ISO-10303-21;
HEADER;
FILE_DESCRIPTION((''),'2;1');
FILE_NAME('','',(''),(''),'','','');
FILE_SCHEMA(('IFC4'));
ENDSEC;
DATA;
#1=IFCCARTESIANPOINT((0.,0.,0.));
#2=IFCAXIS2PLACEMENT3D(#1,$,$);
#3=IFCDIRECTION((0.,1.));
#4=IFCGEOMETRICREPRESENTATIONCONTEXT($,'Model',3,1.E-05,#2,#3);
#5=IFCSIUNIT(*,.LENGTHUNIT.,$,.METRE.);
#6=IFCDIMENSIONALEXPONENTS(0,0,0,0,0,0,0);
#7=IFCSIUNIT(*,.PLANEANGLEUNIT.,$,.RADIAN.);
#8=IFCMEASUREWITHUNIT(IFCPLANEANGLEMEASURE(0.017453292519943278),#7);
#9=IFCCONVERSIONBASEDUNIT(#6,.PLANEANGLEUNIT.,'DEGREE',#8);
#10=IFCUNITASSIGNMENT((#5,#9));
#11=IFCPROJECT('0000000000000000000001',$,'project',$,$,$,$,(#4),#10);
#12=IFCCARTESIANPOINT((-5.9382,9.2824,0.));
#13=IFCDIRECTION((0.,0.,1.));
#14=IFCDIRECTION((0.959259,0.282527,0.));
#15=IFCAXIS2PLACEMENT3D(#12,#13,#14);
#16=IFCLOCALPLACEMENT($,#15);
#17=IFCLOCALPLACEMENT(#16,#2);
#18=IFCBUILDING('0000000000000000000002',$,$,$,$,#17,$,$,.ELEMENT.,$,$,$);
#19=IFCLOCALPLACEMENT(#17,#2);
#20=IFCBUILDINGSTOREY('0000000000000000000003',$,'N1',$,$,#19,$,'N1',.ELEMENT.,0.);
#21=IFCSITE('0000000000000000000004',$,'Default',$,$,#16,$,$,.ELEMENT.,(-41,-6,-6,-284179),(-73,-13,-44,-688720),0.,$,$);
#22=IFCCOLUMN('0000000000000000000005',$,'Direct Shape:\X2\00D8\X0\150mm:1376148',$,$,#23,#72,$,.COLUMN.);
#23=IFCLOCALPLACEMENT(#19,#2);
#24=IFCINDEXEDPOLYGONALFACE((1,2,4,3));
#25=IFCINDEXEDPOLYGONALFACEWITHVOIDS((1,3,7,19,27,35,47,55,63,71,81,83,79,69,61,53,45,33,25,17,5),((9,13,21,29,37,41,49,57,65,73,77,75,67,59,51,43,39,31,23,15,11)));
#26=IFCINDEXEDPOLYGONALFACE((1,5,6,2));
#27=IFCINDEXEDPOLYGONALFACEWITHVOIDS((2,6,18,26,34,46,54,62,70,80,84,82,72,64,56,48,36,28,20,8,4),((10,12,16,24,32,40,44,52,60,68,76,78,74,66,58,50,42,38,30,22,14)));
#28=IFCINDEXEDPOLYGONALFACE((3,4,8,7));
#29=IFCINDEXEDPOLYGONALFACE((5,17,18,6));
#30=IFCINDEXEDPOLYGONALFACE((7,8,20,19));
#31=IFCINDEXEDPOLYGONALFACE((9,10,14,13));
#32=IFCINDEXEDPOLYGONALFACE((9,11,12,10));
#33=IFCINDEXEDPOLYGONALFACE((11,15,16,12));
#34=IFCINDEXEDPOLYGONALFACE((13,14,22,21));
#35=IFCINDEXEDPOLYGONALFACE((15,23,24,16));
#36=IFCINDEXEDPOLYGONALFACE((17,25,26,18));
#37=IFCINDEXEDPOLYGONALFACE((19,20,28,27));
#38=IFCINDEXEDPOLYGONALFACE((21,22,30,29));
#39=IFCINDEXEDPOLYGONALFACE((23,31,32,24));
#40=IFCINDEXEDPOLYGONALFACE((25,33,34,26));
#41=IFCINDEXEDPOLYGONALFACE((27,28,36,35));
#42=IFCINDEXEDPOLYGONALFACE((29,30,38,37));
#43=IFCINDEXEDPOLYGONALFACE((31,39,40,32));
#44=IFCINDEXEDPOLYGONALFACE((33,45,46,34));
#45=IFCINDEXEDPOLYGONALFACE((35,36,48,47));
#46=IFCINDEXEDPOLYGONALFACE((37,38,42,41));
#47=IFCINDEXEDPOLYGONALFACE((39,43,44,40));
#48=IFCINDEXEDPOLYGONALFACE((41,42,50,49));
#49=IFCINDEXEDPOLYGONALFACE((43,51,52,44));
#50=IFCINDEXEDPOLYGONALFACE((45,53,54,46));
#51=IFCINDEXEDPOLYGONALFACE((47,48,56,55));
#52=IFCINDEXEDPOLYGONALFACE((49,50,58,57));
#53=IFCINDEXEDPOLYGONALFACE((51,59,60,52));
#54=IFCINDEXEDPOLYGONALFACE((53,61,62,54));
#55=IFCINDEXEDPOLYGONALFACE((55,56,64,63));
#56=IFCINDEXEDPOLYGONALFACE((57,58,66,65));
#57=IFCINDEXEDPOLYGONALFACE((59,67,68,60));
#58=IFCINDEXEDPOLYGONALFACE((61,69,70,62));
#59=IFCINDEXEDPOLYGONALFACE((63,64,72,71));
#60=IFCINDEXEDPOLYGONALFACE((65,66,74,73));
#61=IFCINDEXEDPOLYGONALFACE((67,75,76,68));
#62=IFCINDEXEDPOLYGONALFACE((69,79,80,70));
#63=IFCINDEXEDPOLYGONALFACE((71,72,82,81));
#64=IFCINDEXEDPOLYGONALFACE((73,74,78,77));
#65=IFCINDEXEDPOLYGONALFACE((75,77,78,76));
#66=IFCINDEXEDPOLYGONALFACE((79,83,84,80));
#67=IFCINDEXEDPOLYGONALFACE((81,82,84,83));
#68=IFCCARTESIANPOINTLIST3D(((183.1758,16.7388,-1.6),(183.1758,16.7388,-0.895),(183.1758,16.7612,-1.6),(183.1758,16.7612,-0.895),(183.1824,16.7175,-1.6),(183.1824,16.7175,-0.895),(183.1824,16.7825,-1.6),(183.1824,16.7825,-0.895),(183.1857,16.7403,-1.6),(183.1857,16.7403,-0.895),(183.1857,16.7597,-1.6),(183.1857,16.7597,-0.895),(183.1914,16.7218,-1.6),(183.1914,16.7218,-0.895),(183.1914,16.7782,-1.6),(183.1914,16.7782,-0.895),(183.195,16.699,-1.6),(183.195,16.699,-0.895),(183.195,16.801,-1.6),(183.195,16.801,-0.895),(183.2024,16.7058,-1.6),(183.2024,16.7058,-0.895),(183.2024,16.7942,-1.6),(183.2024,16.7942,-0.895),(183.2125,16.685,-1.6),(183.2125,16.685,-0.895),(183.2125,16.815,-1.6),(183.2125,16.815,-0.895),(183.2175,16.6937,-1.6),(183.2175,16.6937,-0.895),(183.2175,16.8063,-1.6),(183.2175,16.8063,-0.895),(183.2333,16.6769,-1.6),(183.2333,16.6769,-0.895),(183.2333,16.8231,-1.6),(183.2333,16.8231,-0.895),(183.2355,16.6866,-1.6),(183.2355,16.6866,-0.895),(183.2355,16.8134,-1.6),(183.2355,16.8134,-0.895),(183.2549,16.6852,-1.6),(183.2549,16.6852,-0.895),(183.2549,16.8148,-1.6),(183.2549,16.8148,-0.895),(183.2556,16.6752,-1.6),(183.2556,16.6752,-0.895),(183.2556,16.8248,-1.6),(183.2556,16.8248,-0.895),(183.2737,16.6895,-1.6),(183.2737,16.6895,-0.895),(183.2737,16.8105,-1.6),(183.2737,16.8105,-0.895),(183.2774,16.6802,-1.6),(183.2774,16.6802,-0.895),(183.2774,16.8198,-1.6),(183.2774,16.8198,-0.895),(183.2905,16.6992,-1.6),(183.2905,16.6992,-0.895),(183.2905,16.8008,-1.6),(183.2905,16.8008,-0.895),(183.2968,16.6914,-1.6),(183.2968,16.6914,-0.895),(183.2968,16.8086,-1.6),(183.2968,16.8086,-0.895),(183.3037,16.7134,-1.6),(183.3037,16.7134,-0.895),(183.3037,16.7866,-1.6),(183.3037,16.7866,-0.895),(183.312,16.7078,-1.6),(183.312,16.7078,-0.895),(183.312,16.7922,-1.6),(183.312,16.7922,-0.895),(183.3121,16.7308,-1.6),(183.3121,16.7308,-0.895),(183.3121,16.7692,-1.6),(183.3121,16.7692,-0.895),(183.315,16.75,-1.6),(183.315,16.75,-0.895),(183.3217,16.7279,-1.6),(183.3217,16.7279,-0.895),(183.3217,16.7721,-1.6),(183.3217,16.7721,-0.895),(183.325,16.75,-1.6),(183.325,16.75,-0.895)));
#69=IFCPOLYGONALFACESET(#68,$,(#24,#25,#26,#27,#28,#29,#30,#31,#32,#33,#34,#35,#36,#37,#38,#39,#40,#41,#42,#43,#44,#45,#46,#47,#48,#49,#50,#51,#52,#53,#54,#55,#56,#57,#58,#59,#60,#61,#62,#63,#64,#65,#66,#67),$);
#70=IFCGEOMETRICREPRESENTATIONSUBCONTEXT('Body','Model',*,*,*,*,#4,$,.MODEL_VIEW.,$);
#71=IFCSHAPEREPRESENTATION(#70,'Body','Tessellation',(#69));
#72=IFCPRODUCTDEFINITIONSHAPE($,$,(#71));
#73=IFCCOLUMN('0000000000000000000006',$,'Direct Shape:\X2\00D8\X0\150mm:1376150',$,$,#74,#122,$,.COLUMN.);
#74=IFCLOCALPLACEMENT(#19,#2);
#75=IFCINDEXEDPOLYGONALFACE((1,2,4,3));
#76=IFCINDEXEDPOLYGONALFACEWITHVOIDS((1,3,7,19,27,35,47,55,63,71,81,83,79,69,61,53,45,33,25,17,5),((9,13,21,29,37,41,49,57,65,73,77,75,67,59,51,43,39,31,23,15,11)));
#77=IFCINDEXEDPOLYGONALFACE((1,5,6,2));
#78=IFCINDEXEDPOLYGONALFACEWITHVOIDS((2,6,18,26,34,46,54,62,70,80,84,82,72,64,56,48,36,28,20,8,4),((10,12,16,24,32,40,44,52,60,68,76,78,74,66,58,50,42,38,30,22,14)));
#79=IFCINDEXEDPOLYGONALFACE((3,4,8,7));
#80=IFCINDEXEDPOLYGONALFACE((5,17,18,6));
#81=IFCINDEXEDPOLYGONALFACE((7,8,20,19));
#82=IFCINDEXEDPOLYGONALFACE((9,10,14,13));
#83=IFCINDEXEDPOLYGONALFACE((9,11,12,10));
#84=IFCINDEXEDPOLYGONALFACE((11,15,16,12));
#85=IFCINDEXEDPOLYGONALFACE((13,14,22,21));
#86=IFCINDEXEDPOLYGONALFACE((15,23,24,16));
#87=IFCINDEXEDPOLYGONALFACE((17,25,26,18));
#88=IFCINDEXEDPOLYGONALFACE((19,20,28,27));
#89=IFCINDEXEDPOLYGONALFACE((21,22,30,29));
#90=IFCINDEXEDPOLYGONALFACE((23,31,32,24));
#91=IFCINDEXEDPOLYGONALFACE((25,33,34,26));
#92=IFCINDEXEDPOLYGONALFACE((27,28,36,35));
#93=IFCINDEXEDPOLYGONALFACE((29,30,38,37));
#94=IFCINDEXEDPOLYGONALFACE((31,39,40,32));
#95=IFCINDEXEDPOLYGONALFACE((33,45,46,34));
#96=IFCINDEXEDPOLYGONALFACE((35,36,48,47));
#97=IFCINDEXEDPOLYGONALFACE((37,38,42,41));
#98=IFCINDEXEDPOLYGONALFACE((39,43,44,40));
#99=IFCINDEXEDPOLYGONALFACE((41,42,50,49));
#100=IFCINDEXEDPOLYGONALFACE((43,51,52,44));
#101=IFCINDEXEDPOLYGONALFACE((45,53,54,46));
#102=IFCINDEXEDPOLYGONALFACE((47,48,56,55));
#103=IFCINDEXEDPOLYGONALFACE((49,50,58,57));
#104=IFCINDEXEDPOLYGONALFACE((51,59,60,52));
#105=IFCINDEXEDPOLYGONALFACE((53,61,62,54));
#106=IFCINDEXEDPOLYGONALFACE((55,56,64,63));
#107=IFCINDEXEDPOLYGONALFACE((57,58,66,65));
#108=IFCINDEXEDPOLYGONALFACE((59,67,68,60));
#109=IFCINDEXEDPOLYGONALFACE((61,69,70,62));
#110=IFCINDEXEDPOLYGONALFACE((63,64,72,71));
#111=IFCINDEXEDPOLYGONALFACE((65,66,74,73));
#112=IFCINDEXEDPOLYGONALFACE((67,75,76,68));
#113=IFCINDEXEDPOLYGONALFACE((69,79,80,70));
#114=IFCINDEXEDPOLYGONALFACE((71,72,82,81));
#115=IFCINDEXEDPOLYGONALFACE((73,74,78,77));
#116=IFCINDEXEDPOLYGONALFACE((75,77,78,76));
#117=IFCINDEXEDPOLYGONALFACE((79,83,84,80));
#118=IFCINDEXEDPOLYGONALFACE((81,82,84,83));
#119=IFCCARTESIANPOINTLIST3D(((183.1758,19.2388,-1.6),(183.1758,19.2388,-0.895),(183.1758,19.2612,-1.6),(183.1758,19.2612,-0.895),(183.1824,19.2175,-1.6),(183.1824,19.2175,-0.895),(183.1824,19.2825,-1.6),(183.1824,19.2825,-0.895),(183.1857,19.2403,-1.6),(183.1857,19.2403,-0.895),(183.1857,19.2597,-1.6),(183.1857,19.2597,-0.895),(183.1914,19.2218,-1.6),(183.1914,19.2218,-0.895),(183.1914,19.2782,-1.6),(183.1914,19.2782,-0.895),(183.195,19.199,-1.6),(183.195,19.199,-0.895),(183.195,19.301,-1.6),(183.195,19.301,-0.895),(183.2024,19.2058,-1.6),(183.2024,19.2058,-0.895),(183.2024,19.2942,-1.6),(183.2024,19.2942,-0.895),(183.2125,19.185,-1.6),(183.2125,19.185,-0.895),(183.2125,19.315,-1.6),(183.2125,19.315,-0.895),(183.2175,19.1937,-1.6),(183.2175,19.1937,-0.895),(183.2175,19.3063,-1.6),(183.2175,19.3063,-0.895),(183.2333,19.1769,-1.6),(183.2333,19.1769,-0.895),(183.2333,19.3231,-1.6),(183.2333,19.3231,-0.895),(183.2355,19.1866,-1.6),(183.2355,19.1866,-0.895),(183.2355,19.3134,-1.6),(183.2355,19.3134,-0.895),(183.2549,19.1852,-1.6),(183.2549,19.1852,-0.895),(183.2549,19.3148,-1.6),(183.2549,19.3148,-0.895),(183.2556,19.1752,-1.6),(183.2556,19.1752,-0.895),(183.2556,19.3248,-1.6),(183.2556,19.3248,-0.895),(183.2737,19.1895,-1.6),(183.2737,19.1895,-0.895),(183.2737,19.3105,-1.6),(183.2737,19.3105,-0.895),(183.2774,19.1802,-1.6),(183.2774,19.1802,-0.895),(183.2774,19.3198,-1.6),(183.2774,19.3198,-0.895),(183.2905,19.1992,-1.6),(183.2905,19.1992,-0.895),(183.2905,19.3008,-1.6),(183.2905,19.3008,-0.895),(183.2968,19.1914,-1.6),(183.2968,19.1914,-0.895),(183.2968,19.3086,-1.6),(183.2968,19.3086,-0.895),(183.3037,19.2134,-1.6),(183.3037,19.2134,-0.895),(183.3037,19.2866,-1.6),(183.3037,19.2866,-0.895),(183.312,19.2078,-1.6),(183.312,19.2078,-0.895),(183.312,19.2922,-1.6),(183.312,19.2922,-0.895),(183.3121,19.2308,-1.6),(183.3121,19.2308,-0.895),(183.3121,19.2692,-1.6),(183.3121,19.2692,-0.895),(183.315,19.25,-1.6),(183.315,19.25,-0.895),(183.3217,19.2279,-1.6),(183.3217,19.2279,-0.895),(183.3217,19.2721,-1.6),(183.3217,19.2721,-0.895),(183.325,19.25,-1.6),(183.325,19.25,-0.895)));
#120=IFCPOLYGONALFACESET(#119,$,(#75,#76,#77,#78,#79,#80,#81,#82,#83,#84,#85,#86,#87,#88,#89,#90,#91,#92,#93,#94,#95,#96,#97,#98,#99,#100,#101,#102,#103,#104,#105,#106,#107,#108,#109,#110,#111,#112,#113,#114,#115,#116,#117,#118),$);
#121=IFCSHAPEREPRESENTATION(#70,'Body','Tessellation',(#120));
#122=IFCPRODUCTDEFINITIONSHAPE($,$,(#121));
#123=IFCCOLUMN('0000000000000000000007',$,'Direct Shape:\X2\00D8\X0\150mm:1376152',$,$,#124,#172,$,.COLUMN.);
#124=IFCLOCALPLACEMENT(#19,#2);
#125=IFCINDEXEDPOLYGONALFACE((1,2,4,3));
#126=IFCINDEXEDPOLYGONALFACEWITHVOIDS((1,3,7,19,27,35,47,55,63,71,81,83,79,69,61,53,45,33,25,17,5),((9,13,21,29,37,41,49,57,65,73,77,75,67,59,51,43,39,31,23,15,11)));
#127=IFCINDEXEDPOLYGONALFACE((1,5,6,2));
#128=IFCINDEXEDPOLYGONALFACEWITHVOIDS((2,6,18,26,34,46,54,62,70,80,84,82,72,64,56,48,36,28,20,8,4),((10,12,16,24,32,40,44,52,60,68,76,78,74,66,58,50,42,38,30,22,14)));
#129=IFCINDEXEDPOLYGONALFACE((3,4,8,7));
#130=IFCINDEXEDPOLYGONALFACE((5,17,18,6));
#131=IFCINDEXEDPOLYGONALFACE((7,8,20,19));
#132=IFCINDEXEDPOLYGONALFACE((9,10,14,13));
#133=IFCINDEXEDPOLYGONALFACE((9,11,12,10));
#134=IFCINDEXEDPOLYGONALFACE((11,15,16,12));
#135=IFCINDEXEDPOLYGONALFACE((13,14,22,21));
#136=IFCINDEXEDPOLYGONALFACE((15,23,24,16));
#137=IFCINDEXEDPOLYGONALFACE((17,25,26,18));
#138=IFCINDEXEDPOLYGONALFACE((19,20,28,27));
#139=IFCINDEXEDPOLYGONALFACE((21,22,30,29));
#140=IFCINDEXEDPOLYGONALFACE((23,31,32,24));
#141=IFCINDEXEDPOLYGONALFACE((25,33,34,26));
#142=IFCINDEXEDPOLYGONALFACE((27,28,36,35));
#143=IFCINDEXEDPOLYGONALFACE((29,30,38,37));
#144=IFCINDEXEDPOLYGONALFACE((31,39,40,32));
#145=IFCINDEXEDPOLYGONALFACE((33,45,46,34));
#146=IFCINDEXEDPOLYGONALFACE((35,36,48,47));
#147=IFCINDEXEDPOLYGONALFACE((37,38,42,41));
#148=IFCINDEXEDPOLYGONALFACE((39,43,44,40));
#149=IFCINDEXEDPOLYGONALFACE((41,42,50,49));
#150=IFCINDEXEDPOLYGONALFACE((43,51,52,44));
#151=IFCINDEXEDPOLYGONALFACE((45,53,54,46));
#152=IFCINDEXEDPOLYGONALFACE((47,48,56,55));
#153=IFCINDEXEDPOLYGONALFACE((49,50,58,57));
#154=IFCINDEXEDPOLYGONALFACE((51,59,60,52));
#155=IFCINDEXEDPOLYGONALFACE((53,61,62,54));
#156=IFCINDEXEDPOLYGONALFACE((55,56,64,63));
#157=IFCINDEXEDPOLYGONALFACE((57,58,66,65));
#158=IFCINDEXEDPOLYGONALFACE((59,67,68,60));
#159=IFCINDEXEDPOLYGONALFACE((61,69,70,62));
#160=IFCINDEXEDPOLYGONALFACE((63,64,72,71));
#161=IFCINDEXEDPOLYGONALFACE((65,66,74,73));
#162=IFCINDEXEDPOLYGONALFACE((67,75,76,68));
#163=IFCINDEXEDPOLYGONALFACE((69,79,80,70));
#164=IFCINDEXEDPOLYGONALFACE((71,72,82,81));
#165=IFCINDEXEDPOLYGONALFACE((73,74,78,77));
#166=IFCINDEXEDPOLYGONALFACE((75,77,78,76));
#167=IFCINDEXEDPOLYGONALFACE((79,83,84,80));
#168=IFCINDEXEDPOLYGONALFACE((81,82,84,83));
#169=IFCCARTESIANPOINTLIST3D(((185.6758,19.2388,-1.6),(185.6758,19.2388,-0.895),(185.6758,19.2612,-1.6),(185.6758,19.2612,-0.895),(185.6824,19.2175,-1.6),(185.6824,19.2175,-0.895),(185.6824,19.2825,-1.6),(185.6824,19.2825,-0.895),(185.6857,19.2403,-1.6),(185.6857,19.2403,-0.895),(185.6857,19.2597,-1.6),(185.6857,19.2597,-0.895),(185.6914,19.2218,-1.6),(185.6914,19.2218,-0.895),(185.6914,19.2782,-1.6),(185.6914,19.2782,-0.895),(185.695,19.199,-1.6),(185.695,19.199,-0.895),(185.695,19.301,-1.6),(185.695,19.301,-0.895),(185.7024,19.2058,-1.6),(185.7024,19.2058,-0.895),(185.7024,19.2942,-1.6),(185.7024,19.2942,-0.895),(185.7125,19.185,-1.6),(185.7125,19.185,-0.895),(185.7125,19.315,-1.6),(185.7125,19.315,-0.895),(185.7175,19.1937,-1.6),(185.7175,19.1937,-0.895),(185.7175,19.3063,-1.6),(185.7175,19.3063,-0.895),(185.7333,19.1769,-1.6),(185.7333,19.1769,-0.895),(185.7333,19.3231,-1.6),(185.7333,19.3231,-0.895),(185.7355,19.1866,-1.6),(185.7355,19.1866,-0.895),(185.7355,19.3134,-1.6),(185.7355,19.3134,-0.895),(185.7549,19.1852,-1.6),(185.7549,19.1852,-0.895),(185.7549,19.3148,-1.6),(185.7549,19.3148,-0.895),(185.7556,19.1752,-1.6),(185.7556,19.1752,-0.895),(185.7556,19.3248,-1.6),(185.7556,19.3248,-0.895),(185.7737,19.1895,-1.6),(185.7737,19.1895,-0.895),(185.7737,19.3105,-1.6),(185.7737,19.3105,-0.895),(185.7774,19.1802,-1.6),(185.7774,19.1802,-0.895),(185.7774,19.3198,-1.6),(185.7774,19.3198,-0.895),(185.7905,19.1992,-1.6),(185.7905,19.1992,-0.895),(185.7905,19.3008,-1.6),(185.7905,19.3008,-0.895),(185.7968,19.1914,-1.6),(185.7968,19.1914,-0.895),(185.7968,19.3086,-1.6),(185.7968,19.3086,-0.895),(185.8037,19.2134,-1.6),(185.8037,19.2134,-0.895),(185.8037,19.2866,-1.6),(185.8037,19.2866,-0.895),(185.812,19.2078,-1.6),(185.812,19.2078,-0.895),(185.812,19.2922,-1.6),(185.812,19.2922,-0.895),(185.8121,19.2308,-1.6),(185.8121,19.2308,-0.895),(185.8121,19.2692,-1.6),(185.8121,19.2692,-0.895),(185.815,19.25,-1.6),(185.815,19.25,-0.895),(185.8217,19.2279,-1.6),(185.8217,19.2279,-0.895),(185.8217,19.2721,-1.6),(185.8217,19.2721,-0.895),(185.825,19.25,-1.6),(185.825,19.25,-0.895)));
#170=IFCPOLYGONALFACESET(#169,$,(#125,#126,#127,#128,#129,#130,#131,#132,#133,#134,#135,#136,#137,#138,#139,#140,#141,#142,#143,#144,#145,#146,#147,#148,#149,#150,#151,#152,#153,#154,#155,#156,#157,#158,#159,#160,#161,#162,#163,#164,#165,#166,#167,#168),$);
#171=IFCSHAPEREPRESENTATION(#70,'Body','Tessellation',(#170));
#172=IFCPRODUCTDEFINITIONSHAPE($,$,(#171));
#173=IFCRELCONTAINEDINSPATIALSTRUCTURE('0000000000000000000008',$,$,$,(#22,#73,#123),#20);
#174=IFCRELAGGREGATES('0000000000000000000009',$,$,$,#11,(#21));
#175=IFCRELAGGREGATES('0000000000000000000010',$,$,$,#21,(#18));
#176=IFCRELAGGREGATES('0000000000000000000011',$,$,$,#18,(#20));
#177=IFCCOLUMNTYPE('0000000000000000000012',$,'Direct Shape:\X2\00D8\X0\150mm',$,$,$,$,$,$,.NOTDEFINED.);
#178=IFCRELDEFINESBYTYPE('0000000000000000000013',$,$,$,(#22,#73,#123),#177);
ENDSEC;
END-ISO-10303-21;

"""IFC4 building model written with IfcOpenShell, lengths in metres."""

from ifc_helpers import new_model, entity, si_unit, converted_unit, direction, frame, origin, origin_2d_with_axis, place, context, subcontext, project, spatial, hollow_circle, extrude, type_object, element, save


model = new_model("IFC4")

# Units and contexts
model_context = context("Model", 3, precision=1e-05, world=origin(), true_north=direction((0.0, 1.0)))
body_context = subcontext(model_context, "Body", "Model", "MODEL_VIEW")
ifc_project = project(units=[si_unit("LENGTHUNIT", "METRE"), converted_unit("PLANEANGLEUNIT", "DEGREE", entity("IfcPlaneAngleMeasure", 0.017453292519943278), si_unit("PLANEANGLEUNIT", "RADIAN"), dimensions=[0, 0, 0, 0, 0, 0, 0])], contexts=[model_context])

# Site, building, storey
site_placement = place(None, frame((-5.9382, 9.2824, 0.0), z_axis=(0.0, 0.0, 1.0), x_axis=(0.959259, 0.282527, 0.0)))
site = spatial("IfcSite", under=ifc_project, at=site_placement, Name="Default", CompositionType="ELEMENT", RefLatitude=(-41, -6, -6, -284179), RefLongitude=(-73, -13, -44, -688720), RefElevation=0.0)
building_placement = place(site_placement, origin())
building = spatial("IfcBuilding", under=site, at=building_placement, CompositionType="ELEMENT")
storey_placement = place(building_placement, origin())
storey = spatial("IfcBuildingStorey", under=building, at=storey_placement, Name="N1", LongName="N1", CompositionType="ELEMENT", Elevation=0.0)

# Columns
column_type = type_object("IfcColumnType", Name="Direct Shape:Ø150mm", PredefinedType="NOTDEFINED")
column_1_placement = place(storey_placement, origin())
element("IfcColumn", 1, at=column_1_placement, inside=storey, type_object=column_type, Name="Direct Shape:Ø150mm:1376148", PredefinedType="COLUMN", context=body_context, shape_type="SweptSolid", body=[
    extrude(hollow_circle(Radius=0.075, WallThickness=0.01, at=origin_2d_with_axis()), frame((183.25, 16.75, -1.6)), (0.0, 0.0, 1.0), 0.705),
])
column_2_placement = place(storey_placement, origin())
element("IfcColumn", 2, at=column_2_placement, inside=storey, type_object=column_type, Name="Direct Shape:Ø150mm:1376150", PredefinedType="COLUMN", context=body_context, shape_type="SweptSolid", body=[
    extrude(hollow_circle(Radius=0.075, WallThickness=0.01, at=origin_2d_with_axis()), frame((183.25, 19.25, -1.6)), (0.0, 0.0, 1.0), 0.705),
])
column_3_placement = place(storey_placement, origin())
element("IfcColumn", 3, at=column_3_placement, inside=storey, type_object=column_type, Name="Direct Shape:Ø150mm:1376152", PredefinedType="COLUMN", context=body_context, shape_type="SweptSolid", body=[
    extrude(hollow_circle(Radius=0.075, WallThickness=0.01, at=origin_2d_with_axis()), frame((185.75, 19.25, -1.6)), (0.0, 0.0, 1.0), 0.705),
])

save(model, "model.ifc")
